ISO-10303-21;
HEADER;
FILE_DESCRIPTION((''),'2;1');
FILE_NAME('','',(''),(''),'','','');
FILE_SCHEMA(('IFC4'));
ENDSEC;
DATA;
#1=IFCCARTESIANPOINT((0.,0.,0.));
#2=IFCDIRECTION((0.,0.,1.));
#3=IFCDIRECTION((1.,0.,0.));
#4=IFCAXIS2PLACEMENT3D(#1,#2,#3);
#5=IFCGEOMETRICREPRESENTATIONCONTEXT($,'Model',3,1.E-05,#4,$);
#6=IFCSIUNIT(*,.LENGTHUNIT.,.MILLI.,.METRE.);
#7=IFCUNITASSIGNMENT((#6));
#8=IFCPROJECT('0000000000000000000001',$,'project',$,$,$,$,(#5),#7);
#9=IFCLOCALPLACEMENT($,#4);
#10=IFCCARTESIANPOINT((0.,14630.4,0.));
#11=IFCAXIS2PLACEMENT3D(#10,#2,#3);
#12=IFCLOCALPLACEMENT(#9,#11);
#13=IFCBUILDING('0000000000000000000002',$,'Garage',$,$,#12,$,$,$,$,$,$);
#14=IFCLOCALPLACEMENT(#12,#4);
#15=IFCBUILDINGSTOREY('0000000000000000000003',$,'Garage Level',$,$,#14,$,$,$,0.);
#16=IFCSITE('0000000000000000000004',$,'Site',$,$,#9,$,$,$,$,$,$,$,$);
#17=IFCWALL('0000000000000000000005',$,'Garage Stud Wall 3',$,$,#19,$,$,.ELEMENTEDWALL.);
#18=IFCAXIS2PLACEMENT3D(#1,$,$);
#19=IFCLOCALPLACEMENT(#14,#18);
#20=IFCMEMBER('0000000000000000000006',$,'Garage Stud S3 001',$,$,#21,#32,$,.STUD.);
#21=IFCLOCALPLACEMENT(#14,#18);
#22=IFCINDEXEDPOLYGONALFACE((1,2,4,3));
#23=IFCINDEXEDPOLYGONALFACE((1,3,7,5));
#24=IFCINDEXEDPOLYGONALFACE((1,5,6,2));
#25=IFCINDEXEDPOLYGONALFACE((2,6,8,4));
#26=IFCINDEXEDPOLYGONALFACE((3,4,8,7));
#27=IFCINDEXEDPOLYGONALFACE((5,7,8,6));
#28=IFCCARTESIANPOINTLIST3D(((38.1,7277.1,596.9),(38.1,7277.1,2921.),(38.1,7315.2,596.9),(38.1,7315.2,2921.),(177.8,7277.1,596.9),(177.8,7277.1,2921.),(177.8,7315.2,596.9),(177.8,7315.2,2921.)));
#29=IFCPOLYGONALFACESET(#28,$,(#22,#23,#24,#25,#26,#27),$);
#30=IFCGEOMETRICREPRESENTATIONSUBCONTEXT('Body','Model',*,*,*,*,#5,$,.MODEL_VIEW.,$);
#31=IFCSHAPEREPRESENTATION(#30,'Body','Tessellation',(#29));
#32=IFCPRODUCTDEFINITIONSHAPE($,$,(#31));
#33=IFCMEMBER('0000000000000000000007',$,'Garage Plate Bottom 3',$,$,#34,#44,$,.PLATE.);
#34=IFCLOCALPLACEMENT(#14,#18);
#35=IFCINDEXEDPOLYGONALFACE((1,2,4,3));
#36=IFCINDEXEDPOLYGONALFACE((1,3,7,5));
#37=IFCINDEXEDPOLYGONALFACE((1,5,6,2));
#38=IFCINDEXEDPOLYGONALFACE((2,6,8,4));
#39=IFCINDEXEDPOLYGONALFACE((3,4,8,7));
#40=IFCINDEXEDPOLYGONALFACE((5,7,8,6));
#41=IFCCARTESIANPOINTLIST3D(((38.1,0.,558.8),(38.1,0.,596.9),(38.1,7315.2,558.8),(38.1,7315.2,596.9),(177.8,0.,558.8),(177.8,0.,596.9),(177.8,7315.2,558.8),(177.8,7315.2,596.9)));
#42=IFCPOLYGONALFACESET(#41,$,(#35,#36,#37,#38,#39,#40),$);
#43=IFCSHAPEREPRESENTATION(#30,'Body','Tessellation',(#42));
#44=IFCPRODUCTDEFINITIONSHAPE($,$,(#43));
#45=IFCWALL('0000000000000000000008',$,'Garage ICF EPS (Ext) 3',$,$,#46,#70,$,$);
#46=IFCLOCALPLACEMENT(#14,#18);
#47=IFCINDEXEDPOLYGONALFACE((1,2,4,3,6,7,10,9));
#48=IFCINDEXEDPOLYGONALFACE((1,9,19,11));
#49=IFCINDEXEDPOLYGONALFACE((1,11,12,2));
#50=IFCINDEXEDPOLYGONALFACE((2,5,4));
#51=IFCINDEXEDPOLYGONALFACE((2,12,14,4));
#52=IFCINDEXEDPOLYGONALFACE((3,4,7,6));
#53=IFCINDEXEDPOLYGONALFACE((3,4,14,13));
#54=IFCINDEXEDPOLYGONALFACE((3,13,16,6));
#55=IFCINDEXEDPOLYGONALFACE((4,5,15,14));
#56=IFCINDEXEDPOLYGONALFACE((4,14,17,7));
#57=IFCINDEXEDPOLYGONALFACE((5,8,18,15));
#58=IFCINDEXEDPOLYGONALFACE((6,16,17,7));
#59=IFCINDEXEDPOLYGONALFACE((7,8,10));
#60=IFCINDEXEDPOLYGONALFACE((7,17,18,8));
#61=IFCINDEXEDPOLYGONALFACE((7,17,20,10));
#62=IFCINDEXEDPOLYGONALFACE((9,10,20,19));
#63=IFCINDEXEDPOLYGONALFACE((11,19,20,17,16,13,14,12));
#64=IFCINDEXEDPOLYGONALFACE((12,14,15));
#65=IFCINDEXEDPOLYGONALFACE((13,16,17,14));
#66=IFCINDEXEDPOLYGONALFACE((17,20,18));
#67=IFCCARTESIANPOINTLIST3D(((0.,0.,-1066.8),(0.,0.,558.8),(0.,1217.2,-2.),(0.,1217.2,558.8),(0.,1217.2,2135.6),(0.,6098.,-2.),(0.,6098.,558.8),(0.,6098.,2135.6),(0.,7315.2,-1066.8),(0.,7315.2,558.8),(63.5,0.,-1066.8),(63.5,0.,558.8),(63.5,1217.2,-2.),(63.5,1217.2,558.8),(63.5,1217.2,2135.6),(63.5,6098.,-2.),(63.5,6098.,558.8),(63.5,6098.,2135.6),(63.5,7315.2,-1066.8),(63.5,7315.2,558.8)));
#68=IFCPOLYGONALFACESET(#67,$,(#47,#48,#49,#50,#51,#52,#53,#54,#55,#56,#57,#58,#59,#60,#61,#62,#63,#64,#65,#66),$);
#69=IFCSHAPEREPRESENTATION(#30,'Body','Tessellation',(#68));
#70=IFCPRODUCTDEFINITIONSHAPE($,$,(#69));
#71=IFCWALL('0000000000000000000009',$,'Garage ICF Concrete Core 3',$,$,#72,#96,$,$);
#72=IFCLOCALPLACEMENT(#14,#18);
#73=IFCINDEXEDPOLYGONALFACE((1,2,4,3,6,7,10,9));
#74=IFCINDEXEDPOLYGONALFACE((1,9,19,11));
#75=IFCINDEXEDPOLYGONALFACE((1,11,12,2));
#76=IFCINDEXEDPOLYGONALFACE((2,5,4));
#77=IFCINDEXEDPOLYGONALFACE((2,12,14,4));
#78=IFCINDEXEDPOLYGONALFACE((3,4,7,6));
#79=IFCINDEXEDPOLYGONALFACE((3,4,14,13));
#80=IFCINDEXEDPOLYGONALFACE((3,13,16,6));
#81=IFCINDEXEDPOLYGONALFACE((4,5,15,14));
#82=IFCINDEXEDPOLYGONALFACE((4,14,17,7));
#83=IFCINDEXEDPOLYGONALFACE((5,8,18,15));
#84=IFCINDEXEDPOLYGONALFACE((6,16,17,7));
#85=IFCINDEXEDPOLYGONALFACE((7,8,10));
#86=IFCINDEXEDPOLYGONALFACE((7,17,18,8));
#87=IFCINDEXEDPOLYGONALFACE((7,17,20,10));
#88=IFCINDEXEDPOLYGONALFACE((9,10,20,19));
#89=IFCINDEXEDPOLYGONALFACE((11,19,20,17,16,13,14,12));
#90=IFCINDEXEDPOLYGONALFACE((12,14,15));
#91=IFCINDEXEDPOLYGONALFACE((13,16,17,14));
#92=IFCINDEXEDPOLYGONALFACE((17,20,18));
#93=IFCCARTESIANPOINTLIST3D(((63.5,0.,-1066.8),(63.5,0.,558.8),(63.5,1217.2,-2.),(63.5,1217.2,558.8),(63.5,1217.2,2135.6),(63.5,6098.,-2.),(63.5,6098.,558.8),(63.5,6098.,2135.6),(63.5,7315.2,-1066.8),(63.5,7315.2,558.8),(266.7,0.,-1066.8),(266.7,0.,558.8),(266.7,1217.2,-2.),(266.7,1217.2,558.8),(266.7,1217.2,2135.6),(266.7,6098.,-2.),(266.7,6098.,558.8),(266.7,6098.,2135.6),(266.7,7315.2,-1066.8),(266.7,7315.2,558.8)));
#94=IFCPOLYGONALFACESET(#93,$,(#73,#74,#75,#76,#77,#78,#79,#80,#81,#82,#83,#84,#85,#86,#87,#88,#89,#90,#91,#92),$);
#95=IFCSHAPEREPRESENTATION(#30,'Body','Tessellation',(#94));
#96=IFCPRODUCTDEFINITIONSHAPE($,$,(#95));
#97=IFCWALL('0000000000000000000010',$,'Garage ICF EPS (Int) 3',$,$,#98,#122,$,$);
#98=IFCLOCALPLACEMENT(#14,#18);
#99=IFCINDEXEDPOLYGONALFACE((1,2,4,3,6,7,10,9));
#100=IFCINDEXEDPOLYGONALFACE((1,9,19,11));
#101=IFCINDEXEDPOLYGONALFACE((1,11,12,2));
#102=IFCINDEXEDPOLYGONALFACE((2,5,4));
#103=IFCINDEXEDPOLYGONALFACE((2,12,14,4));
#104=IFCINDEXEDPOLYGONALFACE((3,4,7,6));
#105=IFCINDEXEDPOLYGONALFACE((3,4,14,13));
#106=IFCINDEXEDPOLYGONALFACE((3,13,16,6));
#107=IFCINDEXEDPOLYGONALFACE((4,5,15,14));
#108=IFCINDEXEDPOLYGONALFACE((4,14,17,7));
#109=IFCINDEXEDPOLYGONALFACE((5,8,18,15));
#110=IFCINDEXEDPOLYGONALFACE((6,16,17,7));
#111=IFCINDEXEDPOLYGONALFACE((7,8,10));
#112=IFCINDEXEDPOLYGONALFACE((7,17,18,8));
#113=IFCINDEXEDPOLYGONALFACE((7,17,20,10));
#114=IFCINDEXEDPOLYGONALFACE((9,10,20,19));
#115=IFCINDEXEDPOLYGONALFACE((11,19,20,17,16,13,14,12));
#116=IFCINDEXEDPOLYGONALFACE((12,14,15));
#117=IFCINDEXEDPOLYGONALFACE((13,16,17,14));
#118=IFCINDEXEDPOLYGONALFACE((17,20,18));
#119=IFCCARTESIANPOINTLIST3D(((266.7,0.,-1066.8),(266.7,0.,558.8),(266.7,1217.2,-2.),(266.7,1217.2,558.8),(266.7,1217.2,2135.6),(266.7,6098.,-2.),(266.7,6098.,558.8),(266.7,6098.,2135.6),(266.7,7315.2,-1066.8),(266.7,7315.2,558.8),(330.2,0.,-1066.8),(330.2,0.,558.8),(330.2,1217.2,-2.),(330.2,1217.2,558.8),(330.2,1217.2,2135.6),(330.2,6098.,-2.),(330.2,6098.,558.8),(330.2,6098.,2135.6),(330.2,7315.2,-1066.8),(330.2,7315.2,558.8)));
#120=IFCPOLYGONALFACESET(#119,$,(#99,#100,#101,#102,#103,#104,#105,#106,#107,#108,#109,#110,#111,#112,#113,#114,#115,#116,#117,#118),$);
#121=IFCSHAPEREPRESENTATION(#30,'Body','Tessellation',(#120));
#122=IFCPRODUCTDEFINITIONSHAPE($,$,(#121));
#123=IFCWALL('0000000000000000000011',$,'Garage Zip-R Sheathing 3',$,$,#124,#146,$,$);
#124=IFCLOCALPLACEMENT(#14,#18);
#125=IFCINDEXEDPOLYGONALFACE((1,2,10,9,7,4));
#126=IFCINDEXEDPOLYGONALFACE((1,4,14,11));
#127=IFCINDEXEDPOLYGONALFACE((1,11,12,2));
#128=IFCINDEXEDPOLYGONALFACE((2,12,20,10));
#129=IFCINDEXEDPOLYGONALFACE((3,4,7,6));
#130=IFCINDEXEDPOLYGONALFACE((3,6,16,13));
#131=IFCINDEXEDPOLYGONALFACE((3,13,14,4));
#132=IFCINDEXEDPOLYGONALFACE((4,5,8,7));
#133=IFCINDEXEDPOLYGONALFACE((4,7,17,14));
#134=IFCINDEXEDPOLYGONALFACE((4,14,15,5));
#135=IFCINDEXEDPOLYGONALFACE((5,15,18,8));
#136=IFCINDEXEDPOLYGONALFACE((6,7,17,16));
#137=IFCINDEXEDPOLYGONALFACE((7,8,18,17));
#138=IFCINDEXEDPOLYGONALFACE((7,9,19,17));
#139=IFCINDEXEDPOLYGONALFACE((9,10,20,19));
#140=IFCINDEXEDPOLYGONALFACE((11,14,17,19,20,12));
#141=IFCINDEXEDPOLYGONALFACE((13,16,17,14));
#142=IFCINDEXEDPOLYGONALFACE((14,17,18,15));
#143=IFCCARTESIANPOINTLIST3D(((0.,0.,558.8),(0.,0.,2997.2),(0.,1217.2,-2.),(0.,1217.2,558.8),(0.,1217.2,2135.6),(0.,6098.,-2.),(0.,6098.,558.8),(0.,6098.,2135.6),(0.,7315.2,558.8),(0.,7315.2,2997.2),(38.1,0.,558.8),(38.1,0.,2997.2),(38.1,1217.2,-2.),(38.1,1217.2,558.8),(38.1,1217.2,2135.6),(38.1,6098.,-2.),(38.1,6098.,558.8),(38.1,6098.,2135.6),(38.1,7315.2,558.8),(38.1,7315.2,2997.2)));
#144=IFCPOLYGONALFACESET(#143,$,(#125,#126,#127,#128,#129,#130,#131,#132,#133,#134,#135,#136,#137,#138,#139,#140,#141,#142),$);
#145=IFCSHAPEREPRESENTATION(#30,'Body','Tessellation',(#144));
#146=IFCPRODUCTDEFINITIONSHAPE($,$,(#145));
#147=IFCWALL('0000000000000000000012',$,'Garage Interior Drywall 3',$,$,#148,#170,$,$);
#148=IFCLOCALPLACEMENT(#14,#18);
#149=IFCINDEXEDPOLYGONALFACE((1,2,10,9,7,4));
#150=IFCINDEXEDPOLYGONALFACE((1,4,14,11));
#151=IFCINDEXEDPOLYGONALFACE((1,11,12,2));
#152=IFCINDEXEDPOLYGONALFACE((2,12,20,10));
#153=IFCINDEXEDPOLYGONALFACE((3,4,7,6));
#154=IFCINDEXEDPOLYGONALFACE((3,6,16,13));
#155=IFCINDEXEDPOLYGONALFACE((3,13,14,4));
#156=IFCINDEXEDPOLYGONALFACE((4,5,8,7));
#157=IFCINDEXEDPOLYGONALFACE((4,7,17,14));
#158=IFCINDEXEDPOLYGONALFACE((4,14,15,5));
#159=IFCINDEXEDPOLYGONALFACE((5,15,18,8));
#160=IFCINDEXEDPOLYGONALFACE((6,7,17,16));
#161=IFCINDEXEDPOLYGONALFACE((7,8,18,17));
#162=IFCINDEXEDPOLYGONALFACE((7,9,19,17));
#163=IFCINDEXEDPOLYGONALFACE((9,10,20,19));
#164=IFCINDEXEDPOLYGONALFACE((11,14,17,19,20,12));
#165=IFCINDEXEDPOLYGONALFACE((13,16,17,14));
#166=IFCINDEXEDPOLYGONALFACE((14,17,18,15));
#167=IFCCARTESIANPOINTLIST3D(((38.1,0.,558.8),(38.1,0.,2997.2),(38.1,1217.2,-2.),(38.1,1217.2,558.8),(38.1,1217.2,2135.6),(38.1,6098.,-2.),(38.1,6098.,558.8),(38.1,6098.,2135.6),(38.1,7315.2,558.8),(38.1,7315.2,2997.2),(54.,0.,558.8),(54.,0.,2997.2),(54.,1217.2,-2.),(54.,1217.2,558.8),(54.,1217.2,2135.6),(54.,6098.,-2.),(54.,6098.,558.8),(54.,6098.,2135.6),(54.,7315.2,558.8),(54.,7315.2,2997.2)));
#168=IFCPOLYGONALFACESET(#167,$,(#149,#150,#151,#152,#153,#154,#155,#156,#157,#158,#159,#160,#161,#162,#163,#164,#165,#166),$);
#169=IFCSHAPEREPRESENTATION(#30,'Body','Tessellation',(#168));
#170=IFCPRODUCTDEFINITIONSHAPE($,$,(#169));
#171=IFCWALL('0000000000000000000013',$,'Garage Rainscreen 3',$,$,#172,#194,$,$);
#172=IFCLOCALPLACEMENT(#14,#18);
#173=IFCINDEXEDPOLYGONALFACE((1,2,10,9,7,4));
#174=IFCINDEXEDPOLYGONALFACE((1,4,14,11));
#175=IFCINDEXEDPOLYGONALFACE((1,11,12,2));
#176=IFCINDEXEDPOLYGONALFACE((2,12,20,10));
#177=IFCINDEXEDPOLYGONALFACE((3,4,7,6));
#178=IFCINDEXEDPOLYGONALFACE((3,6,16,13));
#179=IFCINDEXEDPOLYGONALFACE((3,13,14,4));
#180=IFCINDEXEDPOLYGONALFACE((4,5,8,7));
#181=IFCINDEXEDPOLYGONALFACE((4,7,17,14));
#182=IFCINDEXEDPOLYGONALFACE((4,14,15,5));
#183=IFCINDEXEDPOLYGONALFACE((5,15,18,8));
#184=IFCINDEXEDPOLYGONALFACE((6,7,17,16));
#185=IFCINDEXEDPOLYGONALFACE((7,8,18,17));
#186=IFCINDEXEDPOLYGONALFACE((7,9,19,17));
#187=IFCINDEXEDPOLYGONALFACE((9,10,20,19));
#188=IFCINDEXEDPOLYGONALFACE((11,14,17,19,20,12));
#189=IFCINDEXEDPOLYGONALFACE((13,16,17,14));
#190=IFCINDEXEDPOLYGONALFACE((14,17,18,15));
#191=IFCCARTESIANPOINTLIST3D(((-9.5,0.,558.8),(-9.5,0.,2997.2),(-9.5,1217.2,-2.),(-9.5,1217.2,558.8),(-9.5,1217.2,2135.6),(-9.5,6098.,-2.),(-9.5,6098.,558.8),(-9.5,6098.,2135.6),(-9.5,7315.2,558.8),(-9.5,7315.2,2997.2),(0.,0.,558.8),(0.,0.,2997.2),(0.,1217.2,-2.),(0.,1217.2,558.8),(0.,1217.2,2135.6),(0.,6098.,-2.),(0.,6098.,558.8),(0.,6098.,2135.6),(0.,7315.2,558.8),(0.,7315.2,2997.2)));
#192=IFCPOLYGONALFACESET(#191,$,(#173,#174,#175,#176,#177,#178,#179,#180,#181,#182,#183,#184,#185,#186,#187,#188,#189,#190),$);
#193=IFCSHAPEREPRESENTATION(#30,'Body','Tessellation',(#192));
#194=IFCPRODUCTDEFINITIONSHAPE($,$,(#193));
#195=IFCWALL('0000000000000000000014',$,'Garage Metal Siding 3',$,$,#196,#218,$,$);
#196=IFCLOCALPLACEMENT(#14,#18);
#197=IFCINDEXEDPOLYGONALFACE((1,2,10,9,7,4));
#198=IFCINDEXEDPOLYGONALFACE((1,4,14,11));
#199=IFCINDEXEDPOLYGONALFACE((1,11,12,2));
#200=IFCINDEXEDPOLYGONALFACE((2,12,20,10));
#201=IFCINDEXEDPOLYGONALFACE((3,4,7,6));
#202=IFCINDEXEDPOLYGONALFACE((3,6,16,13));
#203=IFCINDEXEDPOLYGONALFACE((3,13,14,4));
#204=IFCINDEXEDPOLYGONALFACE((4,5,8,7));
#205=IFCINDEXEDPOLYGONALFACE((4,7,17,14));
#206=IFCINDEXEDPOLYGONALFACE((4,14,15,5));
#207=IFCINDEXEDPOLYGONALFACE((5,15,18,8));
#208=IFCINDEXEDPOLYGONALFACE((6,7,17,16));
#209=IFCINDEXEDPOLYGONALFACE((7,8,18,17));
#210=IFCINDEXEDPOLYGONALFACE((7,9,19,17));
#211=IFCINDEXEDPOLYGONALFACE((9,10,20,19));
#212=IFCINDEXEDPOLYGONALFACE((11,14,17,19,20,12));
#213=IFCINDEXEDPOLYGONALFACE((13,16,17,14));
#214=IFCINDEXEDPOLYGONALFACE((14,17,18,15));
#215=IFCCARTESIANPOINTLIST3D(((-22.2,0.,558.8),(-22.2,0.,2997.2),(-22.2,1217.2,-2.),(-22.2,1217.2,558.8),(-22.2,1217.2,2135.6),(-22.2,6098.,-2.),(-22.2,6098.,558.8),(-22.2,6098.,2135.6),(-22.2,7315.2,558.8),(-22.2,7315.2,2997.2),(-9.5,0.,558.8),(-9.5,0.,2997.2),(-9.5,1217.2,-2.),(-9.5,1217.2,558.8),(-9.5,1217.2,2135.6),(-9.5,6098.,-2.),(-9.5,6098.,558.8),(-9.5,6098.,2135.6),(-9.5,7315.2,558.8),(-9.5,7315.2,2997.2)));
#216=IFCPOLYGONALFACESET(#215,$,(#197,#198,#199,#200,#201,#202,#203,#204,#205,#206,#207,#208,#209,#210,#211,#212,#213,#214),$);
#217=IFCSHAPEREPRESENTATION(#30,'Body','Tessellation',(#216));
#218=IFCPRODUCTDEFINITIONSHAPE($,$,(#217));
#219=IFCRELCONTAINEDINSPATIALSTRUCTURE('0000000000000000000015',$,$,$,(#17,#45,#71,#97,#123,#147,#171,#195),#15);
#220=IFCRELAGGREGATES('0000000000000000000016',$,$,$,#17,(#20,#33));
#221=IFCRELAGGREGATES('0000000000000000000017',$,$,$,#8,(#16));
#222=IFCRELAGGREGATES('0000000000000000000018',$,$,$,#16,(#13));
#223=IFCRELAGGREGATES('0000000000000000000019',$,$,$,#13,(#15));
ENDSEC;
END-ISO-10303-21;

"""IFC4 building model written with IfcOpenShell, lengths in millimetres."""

from ifc_helpers import new_model, si_unit, frame, origin_with_axes, origin_2d, place, context, subcontext, project, spatial, indexed_curve, rectangle, outline, extrude, element, aggregate, save


model = new_model("IFC4")

# Units and contexts
model_context = context("Model", 3, precision=1e-05, world=origin_with_axes())
body_context = subcontext(model_context, "Body", "Model", "MODEL_VIEW")
ifc_project = project(units=[si_unit("LENGTHUNIT", "METRE", prefix="MILLI")], contexts=[model_context])

# Site, building, storey
site_placement = place(None, origin_with_axes())
site = spatial("IfcSite", under=ifc_project, at=site_placement, Name="Site")
building_placement = place(site_placement, frame((0.0, 14630.4, 0.0), z_axis=(0.0, 0.0, 1.0), x_axis=(1.0, 0.0, 0.0)))
building = spatial("IfcBuilding", under=site, at=building_placement, Name="Garage")
storey_placement = place(building_placement, origin_with_axes())
storey = spatial("IfcBuildingStorey", under=building, at=storey_placement, Name="Garage Level", Elevation=0.0)

# Wall, members
wall_1_placement = place(storey_placement, frame((0.0, 7315.2, 558.8), z_axis=(0.0, 0.0, 1.0), x_axis=(0.0, -1.0, 0.0)))
wall_1 = element("IfcWall", 1, at=wall_1_placement, inside=storey, Name="Garage Stud Wall 3", PredefinedType="ELEMENTEDWALL")
member_1_placement = place(wall_1_placement, frame((19.1, 108.0, 38.1), z_axis=(0.0, 0.0, 1.0), x_axis=(1.0, 0.0, 0.0)))
member_1 = element("IfcMember", 2, at=member_1_placement, Name="Garage Stud S3 001", PredefinedType="STUD", context=body_context, shape_type="SweptSolid", body=[
    extrude(rectangle(XDim=38.1, YDim=139.7, at=origin_2d()), origin_with_axes(), (0.0, 0.0, 1.0), 2324.1),
])
member_2_placement = place(wall_1_placement, frame((0.0, 108.0, 19.1), z_axis=(1.0, 0.0, 0.0), x_axis=(0.0, 0.0, 1.0)))
member_2 = element("IfcMember", 3, at=member_2_placement, Name="Garage Plate Bottom 3", PredefinedType="PLATE", context=body_context, shape_type="SweptSolid", body=[
    extrude(rectangle(XDim=38.1, YDim=139.7, at=origin_2d()), origin_with_axes(), (0.0, 0.0, 1.0), 7315.2),
])
aggregate(wall_1, [member_1, member_2])

# Walls
wall_2_placement = place(storey_placement, frame((0.0, 7315.2, 0.0), z_axis=(1.0, 0.0, 0.0), x_axis=(0.0, -1.0, 0.0)))
element("IfcWall", 4, at=wall_2_placement, inside=storey, Name="Garage ICF EPS (Ext) 3", context=body_context, shape_type="SweptSolid", body=[
    extrude(outline(indexed_curve([(0.0, 1066.8), (7315.2, 1066.8), (7315.2, -558.8), (0.0, -558.8), (0.0, 1066.8)]), holes=[indexed_curve([(1217.2, 2.0), (6098.0, 2.0), (6098.0, -2135.6), (1217.2, -2135.6), (1217.2, 2.0)])]), origin_with_axes(), (0.0, 0.0, 1.0), 63.5),
])
wall_3_placement = place(storey_placement, frame((63.5, 7315.2, 0.0), z_axis=(1.0, 0.0, 0.0), x_axis=(0.0, -1.0, 0.0)))
element("IfcWall", 5, at=wall_3_placement, inside=storey, Name="Garage ICF Concrete Core 3", context=body_context, shape_type="SweptSolid", body=[
    extrude(outline(indexed_curve([(0.0, 1066.8), (7315.2, 1066.8), (7315.2, -558.8), (0.0, -558.8), (0.0, 1066.8)]), holes=[indexed_curve([(1217.2, 2.0), (6098.0, 2.0), (6098.0, -2135.6), (1217.2, -2135.6), (1217.2, 2.0)])]), origin_with_axes(), (0.0, 0.0, 1.0), 203.2),
])
wall_4_placement = place(storey_placement, frame((266.7, 7315.2, 0.0), z_axis=(1.0, 0.0, 0.0), x_axis=(0.0, -1.0, 0.0)))
element("IfcWall", 6, at=wall_4_placement, inside=storey, Name="Garage ICF EPS (Int) 3", context=body_context, shape_type="SweptSolid", body=[
    extrude(outline(indexed_curve([(0.0, 1066.8), (7315.2, 1066.8), (7315.2, -558.8), (0.0, -558.8), (0.0, 1066.8)]), holes=[indexed_curve([(1217.2, 2.0), (6098.0, 2.0), (6098.0, -2135.6), (1217.2, -2135.6), (1217.2, 2.0)])]), origin_with_axes(), (0.0, 0.0, 1.0), 63.5),
])
wall_5_placement = place(storey_placement, frame((0.0, 7315.2, 0.0), z_axis=(1.0, 0.0, 0.0), x_axis=(0.0, -1.0, 0.0)))
element("IfcWall", 7, at=wall_5_placement, inside=storey, Name="Garage Zip-R Sheathing 3", context=body_context, shape_type="SweptSolid", body=[
    extrude(outline(indexed_curve([(0.0, -558.8), (7315.2, -558.8), (7315.2, -2997.2), (0.0, -2997.2), (0.0, -558.8)]), holes=[indexed_curve([(1217.2, 2.0), (6098.0, 2.0), (6098.0, -2135.6), (1217.2, -2135.6), (1217.2, 2.0)])]), origin_with_axes(), (0.0, 0.0, 1.0), 38.1),
])
wall_6_placement = place(storey_placement, frame((38.1, 7315.2, 0.0), z_axis=(1.0, 0.0, 0.0), x_axis=(0.0, -1.0, 0.0)))
element("IfcWall", 8, at=wall_6_placement, inside=storey, Name="Garage Interior Drywall 3", context=body_context, shape_type="SweptSolid", body=[
    extrude(outline(indexed_curve([(0.0, -558.8), (7315.2, -558.8), (7315.2, -2997.2), (0.0, -2997.2), (0.0, -558.8)]), holes=[indexed_curve([(1217.2, 2.0), (6098.0, 2.0), (6098.0, -2135.6), (1217.2, -2135.6), (1217.2, 2.0)])]), origin_with_axes(), (0.0, 0.0, 1.0), 15.9),
])
wall_7_placement = place(storey_placement, frame((-9.5, 7315.2, 0.0), z_axis=(1.0, 0.0, 0.0), x_axis=(0.0, -1.0, 0.0)))
element("IfcWall", 9, at=wall_7_placement, inside=storey, Name="Garage Rainscreen 3", context=body_context, shape_type="SweptSolid", body=[
    extrude(outline(indexed_curve([(0.0, -558.8), (7315.2, -558.8), (7315.2, -2997.2), (0.0, -2997.2), (0.0, -558.8)]), holes=[indexed_curve([(1217.2, 2.0), (6098.0, 2.0), (6098.0, -2135.6), (1217.2, -2135.6), (1217.2, 2.0)])]), origin_with_axes(), (0.0, 0.0, 1.0), 9.5),
])
wall_8_placement = place(storey_placement, frame((-22.2, 7315.2, 0.0), z_axis=(1.0, 0.0, 0.0), x_axis=(0.0, -1.0, 0.0)))
element("IfcWall", 10, at=wall_8_placement, inside=storey, Name="Garage Metal Siding 3", context=body_context, shape_type="SweptSolid", body=[
    extrude(outline(indexed_curve([(0.0, -558.8), (7315.2, -558.8), (7315.2, -2997.2), (0.0, -2997.2), (0.0, -558.8)]), holes=[indexed_curve([(1217.2, 2.0), (6098.0, 2.0), (6098.0, -2135.6), (1217.2, -2135.6), (1217.2, 2.0)])]), origin_with_axes(), (0.0, 0.0, 1.0), 12.7),
])

save(model, "model.ifc")
